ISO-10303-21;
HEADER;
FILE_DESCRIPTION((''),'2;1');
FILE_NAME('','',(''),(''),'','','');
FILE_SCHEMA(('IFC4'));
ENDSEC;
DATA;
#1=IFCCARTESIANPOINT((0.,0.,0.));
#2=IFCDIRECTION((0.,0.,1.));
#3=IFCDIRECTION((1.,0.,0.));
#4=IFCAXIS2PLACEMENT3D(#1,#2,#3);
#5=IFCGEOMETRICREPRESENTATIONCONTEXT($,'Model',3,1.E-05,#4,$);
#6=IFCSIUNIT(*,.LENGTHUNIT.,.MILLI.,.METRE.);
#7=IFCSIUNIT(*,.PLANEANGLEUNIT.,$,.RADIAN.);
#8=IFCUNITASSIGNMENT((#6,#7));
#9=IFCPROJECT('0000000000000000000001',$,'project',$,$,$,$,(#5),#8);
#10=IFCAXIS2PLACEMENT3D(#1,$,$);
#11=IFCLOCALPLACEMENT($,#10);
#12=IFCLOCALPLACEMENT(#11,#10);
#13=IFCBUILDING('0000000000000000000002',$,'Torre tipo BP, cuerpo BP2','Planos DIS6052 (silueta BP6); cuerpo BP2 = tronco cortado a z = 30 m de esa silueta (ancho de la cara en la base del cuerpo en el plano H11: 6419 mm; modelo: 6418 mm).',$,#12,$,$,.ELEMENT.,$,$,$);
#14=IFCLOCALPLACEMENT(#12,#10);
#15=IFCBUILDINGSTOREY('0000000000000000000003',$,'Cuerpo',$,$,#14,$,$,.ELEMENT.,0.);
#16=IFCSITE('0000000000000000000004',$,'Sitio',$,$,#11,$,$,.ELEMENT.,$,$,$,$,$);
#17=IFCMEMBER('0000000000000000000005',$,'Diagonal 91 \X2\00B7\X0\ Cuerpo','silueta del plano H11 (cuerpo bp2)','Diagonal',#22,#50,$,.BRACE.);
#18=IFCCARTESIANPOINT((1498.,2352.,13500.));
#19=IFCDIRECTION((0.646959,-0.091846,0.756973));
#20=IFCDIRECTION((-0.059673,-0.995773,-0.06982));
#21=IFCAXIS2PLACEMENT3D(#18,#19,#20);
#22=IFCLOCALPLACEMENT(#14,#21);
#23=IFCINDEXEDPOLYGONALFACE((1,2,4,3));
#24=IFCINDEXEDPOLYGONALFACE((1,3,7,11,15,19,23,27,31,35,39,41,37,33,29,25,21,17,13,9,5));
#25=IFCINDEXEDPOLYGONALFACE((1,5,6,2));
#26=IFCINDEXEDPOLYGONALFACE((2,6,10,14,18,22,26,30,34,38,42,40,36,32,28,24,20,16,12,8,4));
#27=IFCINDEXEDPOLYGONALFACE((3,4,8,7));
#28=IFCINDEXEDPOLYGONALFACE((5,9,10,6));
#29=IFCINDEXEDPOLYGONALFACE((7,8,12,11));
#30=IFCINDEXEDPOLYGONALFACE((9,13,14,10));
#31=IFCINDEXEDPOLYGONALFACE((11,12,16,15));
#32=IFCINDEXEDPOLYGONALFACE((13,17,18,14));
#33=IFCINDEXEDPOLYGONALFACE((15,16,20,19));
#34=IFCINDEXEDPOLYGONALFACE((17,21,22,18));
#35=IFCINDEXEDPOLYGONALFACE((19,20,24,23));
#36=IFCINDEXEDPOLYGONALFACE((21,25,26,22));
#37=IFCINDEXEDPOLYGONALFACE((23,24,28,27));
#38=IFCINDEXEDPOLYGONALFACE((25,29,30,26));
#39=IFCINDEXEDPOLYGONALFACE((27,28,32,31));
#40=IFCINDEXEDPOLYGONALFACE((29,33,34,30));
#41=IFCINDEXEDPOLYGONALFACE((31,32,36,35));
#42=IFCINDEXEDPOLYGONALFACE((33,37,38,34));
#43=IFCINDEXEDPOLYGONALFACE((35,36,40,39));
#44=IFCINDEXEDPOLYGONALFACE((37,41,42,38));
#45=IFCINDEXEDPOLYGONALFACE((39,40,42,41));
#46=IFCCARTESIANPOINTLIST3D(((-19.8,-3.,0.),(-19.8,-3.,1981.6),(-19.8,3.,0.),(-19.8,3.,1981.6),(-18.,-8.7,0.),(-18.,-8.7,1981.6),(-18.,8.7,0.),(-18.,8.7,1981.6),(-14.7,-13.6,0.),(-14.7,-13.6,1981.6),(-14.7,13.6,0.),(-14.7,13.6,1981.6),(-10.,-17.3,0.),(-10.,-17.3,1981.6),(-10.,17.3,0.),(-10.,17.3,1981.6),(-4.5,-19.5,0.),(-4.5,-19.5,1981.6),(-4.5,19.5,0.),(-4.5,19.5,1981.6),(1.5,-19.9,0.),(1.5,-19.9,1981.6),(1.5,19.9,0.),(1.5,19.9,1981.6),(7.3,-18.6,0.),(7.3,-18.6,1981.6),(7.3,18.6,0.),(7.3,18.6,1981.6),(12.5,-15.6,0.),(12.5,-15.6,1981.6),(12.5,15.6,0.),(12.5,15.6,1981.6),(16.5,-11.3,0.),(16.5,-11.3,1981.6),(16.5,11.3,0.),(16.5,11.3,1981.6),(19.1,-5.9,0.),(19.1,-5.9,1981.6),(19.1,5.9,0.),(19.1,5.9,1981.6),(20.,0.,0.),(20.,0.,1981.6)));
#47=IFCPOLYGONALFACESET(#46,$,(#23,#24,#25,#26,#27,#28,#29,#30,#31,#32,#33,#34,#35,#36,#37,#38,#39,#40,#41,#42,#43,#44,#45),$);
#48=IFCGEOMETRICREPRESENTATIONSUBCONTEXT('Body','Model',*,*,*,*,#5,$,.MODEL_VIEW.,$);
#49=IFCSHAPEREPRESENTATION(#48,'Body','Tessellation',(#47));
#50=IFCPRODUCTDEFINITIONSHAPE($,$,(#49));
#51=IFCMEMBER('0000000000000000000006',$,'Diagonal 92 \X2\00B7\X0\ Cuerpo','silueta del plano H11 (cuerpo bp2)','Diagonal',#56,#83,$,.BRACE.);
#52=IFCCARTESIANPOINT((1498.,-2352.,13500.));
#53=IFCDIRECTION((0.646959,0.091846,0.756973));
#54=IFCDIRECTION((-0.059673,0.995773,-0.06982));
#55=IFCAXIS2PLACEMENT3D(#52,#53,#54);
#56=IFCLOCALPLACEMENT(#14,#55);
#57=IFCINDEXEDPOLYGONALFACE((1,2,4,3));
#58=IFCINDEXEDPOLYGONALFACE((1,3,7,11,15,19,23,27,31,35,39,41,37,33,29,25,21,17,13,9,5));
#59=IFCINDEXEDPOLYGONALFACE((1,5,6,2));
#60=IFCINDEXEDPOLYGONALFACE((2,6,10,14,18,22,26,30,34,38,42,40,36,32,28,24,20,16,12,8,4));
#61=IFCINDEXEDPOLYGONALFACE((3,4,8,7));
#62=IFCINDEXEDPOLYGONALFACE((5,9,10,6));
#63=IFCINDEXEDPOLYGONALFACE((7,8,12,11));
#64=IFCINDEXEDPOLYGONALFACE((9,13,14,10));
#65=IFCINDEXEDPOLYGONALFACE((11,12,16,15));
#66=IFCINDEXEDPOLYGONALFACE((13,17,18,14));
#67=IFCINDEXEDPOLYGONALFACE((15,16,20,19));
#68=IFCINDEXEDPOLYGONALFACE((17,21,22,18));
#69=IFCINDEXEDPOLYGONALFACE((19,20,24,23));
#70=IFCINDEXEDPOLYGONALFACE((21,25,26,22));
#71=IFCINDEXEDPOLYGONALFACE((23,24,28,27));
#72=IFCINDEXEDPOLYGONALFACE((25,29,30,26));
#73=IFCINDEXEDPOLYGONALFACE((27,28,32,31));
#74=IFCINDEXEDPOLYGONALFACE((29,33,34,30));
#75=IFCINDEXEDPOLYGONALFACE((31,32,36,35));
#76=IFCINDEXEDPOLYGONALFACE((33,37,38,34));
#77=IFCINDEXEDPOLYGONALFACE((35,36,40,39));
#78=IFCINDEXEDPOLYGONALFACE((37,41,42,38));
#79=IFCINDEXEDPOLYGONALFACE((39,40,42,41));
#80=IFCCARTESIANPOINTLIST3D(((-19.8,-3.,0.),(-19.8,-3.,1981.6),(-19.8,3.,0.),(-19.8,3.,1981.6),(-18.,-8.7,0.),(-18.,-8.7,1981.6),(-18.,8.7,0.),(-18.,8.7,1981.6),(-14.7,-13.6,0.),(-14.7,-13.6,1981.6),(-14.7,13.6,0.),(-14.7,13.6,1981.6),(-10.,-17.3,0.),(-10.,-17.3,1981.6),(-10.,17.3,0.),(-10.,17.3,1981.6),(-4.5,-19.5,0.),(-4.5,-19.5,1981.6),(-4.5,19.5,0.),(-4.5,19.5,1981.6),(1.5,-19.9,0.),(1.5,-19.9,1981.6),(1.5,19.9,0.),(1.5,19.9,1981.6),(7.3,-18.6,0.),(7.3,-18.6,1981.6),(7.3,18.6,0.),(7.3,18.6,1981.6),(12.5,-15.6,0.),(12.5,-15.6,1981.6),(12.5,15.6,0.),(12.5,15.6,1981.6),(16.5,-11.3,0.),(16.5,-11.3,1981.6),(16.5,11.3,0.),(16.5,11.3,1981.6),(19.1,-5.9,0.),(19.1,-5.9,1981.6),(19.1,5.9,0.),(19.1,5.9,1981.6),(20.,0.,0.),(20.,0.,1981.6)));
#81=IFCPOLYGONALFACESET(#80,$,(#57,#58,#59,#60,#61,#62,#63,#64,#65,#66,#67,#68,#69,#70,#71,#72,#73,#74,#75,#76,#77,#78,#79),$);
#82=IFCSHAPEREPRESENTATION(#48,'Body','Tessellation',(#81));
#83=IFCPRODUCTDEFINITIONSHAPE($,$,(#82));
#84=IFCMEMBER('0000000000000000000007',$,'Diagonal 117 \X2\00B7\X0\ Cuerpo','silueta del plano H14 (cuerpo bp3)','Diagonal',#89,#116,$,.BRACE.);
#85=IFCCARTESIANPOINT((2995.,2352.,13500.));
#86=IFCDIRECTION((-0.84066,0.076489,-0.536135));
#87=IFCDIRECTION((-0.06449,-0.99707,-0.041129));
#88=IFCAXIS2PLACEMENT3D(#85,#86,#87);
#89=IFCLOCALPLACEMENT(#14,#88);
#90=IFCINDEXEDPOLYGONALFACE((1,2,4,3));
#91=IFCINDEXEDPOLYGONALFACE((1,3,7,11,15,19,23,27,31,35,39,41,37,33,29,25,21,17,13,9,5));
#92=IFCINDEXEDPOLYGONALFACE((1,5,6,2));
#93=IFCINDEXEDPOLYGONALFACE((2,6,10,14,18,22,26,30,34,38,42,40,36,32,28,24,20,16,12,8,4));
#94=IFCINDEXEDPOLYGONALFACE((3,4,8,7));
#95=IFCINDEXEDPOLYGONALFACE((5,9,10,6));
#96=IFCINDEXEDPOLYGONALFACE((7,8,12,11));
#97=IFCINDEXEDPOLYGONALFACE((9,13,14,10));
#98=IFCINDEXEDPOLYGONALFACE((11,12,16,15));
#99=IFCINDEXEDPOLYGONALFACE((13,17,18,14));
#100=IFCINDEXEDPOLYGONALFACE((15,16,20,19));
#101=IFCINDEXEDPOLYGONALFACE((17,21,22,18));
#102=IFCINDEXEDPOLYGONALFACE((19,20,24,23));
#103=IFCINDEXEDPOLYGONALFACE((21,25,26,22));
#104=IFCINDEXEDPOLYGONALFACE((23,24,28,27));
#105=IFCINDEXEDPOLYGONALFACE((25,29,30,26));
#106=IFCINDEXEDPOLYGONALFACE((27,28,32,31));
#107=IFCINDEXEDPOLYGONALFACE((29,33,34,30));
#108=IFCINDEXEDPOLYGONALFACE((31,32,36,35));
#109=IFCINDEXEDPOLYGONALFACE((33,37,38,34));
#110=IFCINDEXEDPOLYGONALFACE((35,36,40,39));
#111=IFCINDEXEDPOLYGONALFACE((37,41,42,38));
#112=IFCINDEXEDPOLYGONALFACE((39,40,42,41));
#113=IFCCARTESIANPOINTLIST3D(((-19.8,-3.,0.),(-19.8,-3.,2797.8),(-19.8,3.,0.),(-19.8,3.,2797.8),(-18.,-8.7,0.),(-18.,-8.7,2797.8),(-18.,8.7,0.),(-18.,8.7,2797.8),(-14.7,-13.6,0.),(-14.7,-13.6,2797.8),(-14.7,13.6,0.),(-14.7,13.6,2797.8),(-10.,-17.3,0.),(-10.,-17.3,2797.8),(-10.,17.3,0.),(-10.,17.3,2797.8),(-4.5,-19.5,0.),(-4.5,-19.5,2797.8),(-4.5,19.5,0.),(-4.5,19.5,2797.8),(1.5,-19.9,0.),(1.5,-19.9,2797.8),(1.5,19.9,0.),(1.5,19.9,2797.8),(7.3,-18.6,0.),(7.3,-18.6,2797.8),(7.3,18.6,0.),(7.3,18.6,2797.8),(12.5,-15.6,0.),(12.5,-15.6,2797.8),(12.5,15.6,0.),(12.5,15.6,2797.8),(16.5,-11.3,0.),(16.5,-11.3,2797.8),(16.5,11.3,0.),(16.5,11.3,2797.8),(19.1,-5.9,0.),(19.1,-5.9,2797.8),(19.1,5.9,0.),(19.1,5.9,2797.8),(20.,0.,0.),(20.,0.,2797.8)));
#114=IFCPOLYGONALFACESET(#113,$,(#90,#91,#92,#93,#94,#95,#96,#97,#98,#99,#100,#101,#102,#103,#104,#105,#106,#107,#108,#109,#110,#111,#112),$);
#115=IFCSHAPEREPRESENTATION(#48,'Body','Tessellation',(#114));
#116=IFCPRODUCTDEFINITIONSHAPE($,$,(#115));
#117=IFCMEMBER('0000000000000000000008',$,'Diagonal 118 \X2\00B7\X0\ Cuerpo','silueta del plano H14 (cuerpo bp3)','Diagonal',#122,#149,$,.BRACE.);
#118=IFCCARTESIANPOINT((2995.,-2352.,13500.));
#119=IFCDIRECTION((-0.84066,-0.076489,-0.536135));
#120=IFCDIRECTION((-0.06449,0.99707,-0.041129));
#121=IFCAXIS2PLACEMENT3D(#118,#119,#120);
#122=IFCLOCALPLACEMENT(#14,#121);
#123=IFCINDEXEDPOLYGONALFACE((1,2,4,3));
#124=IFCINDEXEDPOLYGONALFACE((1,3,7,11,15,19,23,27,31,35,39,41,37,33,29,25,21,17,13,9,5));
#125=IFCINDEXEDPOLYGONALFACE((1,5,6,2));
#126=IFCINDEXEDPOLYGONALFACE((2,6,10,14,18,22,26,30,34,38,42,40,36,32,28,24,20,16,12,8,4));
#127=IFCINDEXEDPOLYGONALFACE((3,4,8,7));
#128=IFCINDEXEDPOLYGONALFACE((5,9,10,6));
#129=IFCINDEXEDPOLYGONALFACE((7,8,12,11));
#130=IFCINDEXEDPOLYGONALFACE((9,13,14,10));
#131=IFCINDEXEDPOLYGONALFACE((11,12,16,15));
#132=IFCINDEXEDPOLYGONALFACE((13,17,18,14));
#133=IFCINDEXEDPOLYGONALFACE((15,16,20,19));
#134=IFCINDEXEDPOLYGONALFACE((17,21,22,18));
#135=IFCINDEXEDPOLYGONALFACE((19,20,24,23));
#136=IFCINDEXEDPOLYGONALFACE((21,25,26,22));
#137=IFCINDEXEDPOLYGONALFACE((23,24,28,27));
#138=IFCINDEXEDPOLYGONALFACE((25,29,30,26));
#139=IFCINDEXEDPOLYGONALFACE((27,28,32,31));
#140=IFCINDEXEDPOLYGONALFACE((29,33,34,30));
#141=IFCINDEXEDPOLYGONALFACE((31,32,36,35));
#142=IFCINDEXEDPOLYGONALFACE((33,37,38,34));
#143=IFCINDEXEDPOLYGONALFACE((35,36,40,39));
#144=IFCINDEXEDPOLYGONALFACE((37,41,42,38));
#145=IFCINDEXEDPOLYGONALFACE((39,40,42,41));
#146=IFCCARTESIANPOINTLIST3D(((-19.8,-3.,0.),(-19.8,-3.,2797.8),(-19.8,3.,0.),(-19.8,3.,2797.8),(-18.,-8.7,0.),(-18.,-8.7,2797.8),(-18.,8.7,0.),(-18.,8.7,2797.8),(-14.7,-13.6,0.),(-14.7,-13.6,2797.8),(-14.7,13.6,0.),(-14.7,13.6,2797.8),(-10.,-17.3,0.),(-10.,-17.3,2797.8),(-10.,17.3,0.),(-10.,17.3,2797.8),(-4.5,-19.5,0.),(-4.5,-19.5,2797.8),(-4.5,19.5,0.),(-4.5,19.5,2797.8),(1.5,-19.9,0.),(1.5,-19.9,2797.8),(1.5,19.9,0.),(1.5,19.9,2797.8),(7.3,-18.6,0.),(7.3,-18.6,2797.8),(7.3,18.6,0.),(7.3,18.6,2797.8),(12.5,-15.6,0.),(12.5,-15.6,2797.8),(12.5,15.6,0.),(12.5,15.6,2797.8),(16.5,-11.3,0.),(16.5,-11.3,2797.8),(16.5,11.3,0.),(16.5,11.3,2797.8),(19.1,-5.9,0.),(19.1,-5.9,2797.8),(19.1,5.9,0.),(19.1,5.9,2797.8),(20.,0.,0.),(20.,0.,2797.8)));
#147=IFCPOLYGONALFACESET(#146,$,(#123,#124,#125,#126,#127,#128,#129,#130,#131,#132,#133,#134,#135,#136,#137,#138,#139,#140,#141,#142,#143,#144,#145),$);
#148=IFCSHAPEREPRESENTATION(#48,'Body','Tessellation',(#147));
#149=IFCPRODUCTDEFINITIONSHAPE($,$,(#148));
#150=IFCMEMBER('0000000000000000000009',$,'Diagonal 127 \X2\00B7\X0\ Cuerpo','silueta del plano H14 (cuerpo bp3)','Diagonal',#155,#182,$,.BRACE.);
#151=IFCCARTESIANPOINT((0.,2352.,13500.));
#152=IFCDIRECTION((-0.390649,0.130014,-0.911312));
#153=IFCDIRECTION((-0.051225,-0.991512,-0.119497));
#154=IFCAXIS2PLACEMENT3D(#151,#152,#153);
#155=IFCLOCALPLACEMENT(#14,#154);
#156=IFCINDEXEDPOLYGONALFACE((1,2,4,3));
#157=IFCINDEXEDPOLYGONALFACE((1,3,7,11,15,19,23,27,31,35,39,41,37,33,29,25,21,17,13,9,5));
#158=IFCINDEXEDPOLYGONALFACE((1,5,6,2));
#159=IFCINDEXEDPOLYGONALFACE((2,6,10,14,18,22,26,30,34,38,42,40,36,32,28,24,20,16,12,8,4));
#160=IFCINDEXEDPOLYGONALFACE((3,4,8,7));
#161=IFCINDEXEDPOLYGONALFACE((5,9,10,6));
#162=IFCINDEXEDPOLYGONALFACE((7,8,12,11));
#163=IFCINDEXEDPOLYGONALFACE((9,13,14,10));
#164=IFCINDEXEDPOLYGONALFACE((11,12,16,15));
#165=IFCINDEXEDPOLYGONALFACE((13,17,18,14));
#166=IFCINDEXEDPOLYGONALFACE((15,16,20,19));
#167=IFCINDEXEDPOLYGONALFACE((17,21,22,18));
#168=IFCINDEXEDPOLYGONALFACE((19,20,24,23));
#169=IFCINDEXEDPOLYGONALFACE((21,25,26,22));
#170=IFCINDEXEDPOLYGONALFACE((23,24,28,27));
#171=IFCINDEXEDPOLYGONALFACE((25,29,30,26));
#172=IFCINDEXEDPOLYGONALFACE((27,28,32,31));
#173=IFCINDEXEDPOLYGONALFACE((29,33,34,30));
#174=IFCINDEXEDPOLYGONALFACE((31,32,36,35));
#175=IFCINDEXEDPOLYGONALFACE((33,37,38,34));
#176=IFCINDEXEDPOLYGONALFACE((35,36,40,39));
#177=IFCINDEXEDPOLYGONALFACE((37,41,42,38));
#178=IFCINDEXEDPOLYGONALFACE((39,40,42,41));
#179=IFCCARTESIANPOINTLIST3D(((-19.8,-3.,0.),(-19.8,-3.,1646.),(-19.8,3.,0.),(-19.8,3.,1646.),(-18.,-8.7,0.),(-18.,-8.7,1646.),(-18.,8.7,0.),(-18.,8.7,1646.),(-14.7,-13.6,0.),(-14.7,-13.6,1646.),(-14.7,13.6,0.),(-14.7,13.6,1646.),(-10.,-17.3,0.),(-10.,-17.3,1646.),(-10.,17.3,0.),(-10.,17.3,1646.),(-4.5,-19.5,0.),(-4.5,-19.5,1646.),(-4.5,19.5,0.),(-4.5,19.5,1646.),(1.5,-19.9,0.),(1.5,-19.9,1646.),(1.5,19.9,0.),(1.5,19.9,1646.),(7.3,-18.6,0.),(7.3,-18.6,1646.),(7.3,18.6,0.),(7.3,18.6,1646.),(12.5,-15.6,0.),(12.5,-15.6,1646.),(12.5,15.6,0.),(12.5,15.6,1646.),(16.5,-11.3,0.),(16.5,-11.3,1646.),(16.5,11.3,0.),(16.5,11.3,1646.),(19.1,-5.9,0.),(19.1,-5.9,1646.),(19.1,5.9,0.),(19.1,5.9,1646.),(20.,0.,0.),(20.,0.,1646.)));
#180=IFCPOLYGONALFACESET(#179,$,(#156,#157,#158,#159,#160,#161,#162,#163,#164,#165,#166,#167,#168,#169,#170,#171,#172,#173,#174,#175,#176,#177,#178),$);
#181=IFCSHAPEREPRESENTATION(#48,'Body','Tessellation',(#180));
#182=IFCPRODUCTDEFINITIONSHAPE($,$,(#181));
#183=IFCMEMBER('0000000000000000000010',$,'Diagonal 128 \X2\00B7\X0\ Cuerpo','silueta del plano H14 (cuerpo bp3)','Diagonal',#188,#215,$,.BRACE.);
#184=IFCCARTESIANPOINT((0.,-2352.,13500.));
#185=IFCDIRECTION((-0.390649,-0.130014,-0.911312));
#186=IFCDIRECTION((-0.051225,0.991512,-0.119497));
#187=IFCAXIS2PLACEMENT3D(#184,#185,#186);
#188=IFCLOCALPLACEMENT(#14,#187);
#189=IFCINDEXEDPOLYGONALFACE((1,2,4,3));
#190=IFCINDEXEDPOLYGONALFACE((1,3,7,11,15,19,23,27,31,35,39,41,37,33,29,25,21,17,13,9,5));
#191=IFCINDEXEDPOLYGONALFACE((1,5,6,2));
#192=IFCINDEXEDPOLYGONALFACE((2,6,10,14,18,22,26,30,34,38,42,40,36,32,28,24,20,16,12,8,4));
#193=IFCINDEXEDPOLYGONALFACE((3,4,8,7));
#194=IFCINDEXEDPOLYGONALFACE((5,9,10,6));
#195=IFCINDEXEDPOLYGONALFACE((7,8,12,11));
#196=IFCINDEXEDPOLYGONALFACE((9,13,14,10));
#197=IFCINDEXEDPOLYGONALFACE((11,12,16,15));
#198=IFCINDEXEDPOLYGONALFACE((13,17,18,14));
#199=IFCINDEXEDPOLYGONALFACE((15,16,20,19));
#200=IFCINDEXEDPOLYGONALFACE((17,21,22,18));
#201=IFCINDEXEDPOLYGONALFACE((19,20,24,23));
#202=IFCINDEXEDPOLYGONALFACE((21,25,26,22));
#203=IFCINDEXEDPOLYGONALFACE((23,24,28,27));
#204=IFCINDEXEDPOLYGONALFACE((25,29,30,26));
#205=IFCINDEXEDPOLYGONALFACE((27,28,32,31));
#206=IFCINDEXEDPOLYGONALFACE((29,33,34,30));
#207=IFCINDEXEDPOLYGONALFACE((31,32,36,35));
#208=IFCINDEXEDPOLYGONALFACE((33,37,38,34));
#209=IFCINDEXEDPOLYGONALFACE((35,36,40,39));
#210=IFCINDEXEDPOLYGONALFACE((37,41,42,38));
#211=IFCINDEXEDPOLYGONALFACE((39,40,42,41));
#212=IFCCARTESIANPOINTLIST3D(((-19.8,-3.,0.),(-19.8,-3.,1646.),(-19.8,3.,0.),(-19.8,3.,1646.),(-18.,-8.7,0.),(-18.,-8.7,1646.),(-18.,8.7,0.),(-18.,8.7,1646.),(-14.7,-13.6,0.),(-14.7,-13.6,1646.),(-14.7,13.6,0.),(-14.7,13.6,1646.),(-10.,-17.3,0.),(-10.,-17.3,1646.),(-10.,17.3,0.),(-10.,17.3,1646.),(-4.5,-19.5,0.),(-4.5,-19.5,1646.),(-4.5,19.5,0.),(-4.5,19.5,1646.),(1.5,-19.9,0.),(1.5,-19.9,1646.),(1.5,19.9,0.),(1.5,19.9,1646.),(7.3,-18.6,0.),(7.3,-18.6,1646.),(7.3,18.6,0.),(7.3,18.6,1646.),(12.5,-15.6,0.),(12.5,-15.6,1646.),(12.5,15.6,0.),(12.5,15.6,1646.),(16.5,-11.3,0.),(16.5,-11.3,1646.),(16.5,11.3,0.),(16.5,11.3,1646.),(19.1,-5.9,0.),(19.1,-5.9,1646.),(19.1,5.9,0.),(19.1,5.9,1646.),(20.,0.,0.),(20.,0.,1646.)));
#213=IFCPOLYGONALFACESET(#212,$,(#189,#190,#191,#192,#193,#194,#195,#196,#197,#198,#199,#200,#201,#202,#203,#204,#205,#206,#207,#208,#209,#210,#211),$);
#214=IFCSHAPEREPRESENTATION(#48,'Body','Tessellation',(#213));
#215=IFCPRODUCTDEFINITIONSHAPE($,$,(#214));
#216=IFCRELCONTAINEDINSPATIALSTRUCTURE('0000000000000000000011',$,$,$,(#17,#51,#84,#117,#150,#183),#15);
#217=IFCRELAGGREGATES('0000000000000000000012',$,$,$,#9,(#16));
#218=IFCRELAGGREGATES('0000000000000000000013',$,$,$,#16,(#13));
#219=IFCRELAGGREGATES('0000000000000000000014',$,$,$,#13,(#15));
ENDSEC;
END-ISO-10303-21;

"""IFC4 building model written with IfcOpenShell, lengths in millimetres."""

from ifc_helpers import new_model, si_unit, frame, origin, origin_with_axes, place, context, subcontext, project, spatial, circle, extrude, element, save


model = new_model("IFC4")

# Units and contexts
model_context = context("Model", 3, precision=1e-05, world=origin_with_axes())
body_context = subcontext(model_context, "Body", "Model", "MODEL_VIEW")
ifc_project = project(units=[si_unit("LENGTHUNIT", "METRE", prefix="MILLI"), si_unit("PLANEANGLEUNIT", "RADIAN")], contexts=[model_context])

# Site, building, storey
site_placement = place(None, origin())
site = spatial("IfcSite", under=ifc_project, at=site_placement, Name="Sitio", CompositionType="ELEMENT")
building_placement = place(site_placement, origin())
building = spatial("IfcBuilding", under=site, at=building_placement, Name="Torre tipo BP, cuerpo BP2", Description="Planos DIS6052 (silueta BP6); cuerpo BP2 = tronco cortado a z = 30 m de esa silueta (ancho de la cara en la base del cuerpo en el plano H11: 6419 mm; modelo: 6418 mm).", CompositionType="ELEMENT")
storey_placement = place(building_placement, origin())
storey = spatial("IfcBuildingStorey", under=building, at=storey_placement, Name="Cuerpo", CompositionType="ELEMENT", Elevation=0.0)

# Members
for number, where, z_axis, x_axis, name in (
    (1, (1498.0, 2352.0, 13500.0), (0.646959, -0.091846, 0.756973), (-0.059673, -0.995773, -0.06982), "Diagonal 91 · Cuerpo"),
    (2, (1498.0, -2352.0, 13500.0), (0.646959, 0.091846, 0.756973), (-0.059673, 0.995773, -0.06982), "Diagonal 92 · Cuerpo"),
):
    element("IfcMember", number, at=place(storey_placement, frame(where, z_axis=z_axis, x_axis=x_axis)), inside=storey, Name=name, Description="silueta del plano H11 (cuerpo bp2)", ObjectType="Diagonal", PredefinedType="BRACE", context=body_context, shape_type="SweptSolid", body=[
        extrude(circle(Radius=20.0), None, (0.0, 0.0, 1.0), 1981.6),
    ])
for number, where, z_axis, x_axis, name in (
    (3, (2995.0, 2352.0, 13500.0), (-0.84066, 0.076489, -0.536135), (-0.06449, -0.99707, -0.041129), "Diagonal 117 · Cuerpo"),
    (4, (2995.0, -2352.0, 13500.0), (-0.84066, -0.076489, -0.536135), (-0.06449, 0.99707, -0.041129), "Diagonal 118 · Cuerpo"),
):
    element("IfcMember", number, at=place(storey_placement, frame(where, z_axis=z_axis, x_axis=x_axis)), inside=storey, Name=name, Description="silueta del plano H14 (cuerpo bp3)", ObjectType="Diagonal", PredefinedType="BRACE", context=body_context, shape_type="SweptSolid", body=[
        extrude(circle(Radius=20.0), None, (0.0, 0.0, 1.0), 2797.8),
    ])
for number, where, z_axis, x_axis, name in (
    (5, (0.0, 2352.0, 13500.0), (-0.390649, 0.130014, -0.911312), (-0.051225, -0.991512, -0.119497), "Diagonal 127 · Cuerpo"),
    (6, (0.0, -2352.0, 13500.0), (-0.390649, -0.130014, -0.911312), (-0.051225, 0.991512, -0.119497), "Diagonal 128 · Cuerpo"),
):
    element("IfcMember", number, at=place(storey_placement, frame(where, z_axis=z_axis, x_axis=x_axis)), inside=storey, Name=name, Description="silueta del plano H14 (cuerpo bp3)", ObjectType="Diagonal", PredefinedType="BRACE", context=body_context, shape_type="SweptSolid", body=[
        extrude(circle(Radius=20.0), None, (0.0, 0.0, 1.0), 1646.0),
    ])

save(model, "model.ifc")
